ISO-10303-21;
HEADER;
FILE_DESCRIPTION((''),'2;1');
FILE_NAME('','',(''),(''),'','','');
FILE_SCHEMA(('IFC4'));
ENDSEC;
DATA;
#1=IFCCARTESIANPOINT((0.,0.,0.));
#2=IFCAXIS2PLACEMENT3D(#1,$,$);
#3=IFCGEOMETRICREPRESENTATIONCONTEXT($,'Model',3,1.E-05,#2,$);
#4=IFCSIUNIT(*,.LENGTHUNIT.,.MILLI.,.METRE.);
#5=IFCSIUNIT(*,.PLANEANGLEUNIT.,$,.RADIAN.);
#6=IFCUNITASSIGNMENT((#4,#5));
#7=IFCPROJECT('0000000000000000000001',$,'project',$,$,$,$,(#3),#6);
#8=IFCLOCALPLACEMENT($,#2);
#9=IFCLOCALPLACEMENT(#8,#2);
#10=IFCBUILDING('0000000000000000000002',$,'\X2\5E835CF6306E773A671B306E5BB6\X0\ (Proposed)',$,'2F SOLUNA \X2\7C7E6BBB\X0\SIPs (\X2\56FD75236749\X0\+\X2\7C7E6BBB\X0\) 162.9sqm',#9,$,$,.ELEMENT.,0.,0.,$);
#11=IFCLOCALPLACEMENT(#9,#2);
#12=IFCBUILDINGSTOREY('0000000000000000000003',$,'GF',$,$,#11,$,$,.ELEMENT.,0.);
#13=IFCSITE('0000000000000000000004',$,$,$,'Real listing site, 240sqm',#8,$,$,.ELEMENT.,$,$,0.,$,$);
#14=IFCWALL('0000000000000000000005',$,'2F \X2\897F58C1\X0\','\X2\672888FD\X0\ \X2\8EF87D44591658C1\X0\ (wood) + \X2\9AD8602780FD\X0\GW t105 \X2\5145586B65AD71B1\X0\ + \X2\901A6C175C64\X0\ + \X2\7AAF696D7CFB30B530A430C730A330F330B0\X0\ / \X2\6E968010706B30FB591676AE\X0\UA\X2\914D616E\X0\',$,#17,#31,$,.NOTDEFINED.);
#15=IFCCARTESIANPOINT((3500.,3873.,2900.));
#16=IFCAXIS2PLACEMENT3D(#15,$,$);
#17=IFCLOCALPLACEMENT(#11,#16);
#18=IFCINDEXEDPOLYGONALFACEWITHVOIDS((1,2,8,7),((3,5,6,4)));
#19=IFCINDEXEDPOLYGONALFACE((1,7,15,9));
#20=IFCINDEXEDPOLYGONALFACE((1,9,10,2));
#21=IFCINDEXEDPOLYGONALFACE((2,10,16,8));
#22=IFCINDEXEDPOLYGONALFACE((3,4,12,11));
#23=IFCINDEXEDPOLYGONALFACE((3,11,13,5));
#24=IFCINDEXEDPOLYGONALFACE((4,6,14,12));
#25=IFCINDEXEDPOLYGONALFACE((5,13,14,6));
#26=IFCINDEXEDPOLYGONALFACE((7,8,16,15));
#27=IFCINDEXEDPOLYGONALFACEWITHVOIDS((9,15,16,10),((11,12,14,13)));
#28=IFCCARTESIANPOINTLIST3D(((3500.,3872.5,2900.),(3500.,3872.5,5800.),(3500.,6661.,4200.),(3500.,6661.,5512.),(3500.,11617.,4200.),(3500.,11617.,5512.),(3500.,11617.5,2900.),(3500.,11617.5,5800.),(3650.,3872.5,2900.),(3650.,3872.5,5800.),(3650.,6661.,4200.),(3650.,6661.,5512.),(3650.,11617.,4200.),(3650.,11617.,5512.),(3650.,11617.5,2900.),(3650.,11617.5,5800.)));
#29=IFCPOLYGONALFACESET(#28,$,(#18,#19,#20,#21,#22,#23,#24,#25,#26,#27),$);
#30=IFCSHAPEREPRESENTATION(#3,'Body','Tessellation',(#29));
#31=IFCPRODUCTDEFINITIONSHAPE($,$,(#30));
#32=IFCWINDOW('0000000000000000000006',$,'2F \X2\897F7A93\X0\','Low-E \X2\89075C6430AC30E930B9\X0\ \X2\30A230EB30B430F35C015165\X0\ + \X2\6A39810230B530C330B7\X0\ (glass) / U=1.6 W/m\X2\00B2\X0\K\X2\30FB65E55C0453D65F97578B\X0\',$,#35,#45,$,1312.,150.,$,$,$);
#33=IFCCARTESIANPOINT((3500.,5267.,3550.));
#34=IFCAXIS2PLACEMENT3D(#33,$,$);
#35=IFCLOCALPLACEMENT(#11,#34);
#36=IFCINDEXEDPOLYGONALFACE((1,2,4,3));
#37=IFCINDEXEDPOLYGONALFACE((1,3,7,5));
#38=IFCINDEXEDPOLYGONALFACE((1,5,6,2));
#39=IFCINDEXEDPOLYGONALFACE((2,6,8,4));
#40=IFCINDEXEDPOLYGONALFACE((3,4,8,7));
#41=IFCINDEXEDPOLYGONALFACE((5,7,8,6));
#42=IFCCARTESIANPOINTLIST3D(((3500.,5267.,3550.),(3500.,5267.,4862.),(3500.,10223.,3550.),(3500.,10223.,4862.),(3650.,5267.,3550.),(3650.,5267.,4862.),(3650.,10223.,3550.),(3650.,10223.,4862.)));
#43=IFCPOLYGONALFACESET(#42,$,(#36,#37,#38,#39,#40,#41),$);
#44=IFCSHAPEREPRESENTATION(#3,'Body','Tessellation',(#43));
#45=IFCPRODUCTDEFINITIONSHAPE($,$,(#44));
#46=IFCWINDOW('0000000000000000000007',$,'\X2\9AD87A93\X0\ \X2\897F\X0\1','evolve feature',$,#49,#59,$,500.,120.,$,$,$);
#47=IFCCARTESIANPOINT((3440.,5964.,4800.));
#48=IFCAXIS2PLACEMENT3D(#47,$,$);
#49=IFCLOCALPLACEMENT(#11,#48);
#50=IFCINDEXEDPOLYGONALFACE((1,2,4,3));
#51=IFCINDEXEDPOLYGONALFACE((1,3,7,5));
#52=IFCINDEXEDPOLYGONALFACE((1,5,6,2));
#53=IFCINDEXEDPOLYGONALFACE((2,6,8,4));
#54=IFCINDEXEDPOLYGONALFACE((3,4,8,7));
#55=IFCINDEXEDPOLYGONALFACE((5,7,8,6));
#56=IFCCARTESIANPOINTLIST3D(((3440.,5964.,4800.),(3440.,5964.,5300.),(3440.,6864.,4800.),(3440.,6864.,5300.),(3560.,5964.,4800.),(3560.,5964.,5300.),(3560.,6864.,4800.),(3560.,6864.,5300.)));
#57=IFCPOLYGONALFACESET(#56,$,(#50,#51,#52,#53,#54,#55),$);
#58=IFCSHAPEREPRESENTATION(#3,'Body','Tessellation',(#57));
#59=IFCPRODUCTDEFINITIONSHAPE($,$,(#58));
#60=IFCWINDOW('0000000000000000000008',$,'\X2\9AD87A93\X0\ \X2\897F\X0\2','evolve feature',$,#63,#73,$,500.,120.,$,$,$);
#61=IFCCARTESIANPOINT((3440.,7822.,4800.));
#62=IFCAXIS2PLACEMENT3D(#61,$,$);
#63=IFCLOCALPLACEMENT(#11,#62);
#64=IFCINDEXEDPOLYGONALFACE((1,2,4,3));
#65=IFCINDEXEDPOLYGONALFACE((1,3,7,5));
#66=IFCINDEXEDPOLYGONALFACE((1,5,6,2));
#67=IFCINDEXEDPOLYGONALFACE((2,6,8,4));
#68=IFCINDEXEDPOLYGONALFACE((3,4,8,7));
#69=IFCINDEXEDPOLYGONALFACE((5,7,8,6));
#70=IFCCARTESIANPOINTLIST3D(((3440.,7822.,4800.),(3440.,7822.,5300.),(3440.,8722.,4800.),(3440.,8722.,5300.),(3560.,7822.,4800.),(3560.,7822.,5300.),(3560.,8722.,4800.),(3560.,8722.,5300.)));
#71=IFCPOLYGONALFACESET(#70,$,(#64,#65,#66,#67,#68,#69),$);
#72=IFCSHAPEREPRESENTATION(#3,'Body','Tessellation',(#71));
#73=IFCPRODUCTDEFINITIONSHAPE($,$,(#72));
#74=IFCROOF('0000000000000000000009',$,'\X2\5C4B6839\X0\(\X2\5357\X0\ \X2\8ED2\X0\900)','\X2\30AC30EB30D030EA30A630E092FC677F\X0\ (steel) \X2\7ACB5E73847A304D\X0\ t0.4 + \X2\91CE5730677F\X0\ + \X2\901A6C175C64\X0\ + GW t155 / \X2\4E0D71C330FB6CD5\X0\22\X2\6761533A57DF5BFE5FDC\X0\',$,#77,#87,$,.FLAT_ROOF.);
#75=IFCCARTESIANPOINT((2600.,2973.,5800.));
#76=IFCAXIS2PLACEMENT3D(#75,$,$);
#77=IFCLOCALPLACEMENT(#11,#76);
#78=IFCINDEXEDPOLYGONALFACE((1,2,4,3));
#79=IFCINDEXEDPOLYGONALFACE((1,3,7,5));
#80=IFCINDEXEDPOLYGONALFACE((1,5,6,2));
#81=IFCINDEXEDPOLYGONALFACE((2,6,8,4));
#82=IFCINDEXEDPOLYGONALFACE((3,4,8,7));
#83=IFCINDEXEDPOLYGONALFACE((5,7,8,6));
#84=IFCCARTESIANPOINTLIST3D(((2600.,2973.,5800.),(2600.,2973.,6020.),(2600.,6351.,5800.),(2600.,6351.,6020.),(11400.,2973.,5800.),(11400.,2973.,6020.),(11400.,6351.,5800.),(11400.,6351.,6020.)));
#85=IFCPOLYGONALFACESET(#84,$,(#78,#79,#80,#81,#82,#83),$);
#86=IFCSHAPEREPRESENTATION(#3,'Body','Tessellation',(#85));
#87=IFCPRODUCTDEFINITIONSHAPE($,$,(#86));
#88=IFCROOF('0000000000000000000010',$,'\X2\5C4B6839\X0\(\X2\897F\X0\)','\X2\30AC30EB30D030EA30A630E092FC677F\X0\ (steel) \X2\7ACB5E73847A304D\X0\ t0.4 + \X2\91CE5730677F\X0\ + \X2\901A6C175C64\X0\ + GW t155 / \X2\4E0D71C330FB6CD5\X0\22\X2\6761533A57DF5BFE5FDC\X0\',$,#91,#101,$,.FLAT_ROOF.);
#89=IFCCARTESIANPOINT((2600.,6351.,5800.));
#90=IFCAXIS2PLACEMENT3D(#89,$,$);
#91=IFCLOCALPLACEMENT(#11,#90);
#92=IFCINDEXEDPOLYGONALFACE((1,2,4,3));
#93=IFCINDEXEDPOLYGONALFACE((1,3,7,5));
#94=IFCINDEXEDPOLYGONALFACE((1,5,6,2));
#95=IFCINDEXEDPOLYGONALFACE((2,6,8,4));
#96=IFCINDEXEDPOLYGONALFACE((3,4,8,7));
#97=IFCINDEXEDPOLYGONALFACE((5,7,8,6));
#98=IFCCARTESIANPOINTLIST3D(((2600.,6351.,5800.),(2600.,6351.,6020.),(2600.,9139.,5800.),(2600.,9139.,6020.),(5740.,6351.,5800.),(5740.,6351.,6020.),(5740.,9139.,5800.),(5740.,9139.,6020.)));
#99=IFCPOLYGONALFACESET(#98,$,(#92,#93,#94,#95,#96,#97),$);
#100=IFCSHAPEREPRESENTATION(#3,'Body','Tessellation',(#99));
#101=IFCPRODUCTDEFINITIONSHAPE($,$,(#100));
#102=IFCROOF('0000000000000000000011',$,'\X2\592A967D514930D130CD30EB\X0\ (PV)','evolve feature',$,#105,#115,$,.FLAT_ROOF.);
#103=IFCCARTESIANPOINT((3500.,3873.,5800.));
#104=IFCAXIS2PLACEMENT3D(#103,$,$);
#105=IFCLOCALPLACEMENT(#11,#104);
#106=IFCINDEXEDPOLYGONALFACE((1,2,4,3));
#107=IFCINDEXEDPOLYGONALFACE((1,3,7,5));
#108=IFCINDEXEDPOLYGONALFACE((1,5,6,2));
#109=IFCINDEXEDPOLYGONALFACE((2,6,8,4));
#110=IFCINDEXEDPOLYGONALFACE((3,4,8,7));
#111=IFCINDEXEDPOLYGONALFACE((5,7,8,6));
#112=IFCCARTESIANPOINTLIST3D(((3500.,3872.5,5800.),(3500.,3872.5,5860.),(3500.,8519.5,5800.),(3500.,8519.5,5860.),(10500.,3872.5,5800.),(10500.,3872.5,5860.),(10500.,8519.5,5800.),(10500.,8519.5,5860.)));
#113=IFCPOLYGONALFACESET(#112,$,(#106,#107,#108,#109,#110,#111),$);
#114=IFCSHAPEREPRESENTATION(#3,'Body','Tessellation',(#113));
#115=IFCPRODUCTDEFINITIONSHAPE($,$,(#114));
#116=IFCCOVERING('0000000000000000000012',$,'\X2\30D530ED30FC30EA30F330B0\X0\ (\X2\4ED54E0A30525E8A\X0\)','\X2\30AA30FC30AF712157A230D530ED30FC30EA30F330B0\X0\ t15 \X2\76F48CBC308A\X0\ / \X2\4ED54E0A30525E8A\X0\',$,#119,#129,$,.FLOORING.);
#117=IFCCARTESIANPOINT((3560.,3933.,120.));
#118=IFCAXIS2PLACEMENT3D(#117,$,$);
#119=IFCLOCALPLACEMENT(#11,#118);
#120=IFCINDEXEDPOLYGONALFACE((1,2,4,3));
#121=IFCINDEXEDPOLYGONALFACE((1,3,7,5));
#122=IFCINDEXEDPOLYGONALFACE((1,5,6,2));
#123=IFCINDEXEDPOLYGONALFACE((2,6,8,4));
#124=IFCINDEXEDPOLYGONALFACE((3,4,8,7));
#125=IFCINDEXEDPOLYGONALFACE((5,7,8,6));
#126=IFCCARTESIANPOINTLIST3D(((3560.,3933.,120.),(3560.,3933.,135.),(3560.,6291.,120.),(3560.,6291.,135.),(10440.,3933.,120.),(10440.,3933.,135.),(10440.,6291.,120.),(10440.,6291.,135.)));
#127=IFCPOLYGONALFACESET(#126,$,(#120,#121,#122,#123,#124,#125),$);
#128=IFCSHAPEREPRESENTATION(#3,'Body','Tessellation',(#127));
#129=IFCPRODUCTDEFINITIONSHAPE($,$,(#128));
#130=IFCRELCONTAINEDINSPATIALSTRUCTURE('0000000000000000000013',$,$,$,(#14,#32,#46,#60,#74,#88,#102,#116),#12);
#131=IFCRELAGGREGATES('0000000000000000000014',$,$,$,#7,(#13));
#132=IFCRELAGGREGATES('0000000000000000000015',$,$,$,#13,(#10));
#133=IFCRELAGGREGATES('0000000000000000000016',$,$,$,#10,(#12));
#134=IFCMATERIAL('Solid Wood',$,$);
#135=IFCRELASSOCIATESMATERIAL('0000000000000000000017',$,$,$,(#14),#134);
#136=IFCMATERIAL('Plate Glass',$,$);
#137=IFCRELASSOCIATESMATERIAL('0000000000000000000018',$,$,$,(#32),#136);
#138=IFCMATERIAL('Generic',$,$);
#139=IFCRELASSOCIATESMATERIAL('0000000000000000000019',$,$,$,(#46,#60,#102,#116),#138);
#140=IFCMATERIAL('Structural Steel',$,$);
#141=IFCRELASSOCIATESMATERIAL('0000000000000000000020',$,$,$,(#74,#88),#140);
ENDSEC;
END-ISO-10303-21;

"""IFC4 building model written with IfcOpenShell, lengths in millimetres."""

from ifc_helpers import new_model, si_unit, frame, frame_2d, origin, place, context, project, spatial, rectangle, extrude, material, element, fill, save


model = new_model("IFC4")

# Units and contexts
model_context = context("Model", 3, precision=1e-05, world=origin())
ifc_project = project(units=[si_unit("LENGTHUNIT", "METRE", prefix="MILLI"), si_unit("PLANEANGLEUNIT", "RADIAN")], contexts=[model_context])

# Site, building, storey
site_placement = place(None, origin())
site = spatial("IfcSite", under=ifc_project, at=site_placement, ObjectType="Real listing site, 240sqm", CompositionType="ELEMENT", RefElevation=0.0)
building_placement = place(site_placement, origin())
building = spatial("IfcBuilding", under=site, at=building_placement, Name="広島の眺望の家 (Proposed)", ObjectType="2F SOLUNA 籾殻SIPs (国産杉+籾殻) 162.9sqm", CompositionType="ELEMENT", ElevationOfRefHeight=0.0, ElevationOfTerrain=0.0)
storey_placement = place(building_placement, origin())
storey = spatial("IfcBuildingStorey", under=building, at=storey_placement, Name="GF", CompositionType="ELEMENT", Elevation=0.0)

# Shared definitions
ifc_material_1 = material(Name="Solid Wood")
ifc_material_2 = material(Name="Generic")

# Shared definitions
ifc_material_3 = material(Name="Plate Glass")

# Wall, openings, windows
wall_1_placement = place(storey_placement, frame((3500.0, 3873.0, 2900.0)))
wall_1 = element("IfcWall", 1, at=wall_1_placement, inside=storey, material=ifc_material_1, Name="2F 西壁", Description="木製 軸組外壁 (wood) + 高性能GW t105 充填断熱 + 通気層 + 窯業系サイディング / 準耐火・外皮UA配慮", PredefinedType="NOTDEFINED", context=model_context, shape_type="SweptSolid", body=[
    extrude(rectangle(XDim=150.0, YDim=7745.0, at=frame_2d((75.0, 3872.0))), frame((3500.0, 3873.0, 2900.0)), (0.0, 0.0, 1.0), 2900.0),
])
opening_1_placement = place(storey_placement, frame((3500.0, 5267.0, 3550.0)))
opening_1 = element("IfcOpeningElement", 2, at=opening_1_placement, cuts=wall_1, PredefinedType="NOTDEFINED", context=model_context, shape_type="SweptSolid", body=[
    extrude(rectangle(XDim=150.0, YDim=4956.0, at=frame_2d((75.0, 2478.0))), frame((3500.0, 5267.0, 3550.0)), (0.0, 0.0, 1.0), 1312.0),
])
opening_2_placement = place(storey_placement, frame((3440.0, 5964.0, 4800.0)))
opening_2 = element("IfcOpeningElement", 3, at=opening_2_placement, cuts=wall_1, PredefinedType="NOTDEFINED", context=model_context, shape_type="SweptSolid", body=[
    extrude(rectangle(XDim=120.0, YDim=900.0, at=frame_2d((60.0, 450.0))), frame((3440.0, 5964.0, 4800.0)), (0.0, 0.0, 1.0), 500.0),
])
opening_3_placement = place(storey_placement, frame((3440.0, 7822.0, 4800.0)))
opening_3 = element("IfcOpeningElement", 4, at=opening_3_placement, cuts=wall_1, PredefinedType="NOTDEFINED", context=model_context, shape_type="SweptSolid", body=[
    extrude(rectangle(XDim=120.0, YDim=900.0, at=frame_2d((60.0, 450.0))), frame((3440.0, 7822.0, 4800.0)), (0.0, 0.0, 1.0), 500.0),
])
window_1_placement = place(storey_placement, frame((3500.0, 5267.0, 3550.0)))
window_1 = element("IfcWindow", 5, at=window_1_placement, inside=storey, material=ifc_material_3, Name="2F 西窓", Description="Low-E 複層ガラス アルゴン封入 + 樹脂サッシ (glass) / U=1.6 W/m²K・日射取得型", OverallHeight=1312.0, OverallWidth=150.0, context=model_context, shape_type="SweptSolid", body=[
    extrude(rectangle(XDim=150.0, YDim=4956.0, at=frame_2d((75.0, 2478.0))), frame((3500.0, 5267.0, 3550.0)), (0.0, 0.0, 1.0), 1312.0),
])
fill(opening_1, window_1)
window_2_placement = place(storey_placement, frame((3440.0, 5964.0, 4800.0)))
window_2 = element("IfcWindow", 6, at=window_2_placement, inside=storey, material=ifc_material_2, Name="高窓 西1", Description="evolve feature", OverallHeight=500.0, OverallWidth=120.0, context=model_context, shape_type="SweptSolid", body=[
    extrude(rectangle(XDim=120.0, YDim=900.0, at=frame_2d((60.0, 450.0))), frame((3440.0, 5964.0, 4800.0)), (0.0, 0.0, 1.0), 500.0),
])
fill(opening_2, window_2)
window_3_placement = place(storey_placement, frame((3440.0, 7822.0, 4800.0)))
window_3 = element("IfcWindow", 7, at=window_3_placement, inside=storey, material=ifc_material_2, Name="高窓 西2", Description="evolve feature", OverallHeight=500.0, OverallWidth=120.0, context=model_context, shape_type="SweptSolid", body=[
    extrude(rectangle(XDim=120.0, YDim=900.0, at=frame_2d((60.0, 450.0))), frame((3440.0, 7822.0, 4800.0)), (0.0, 0.0, 1.0), 500.0),
])
fill(opening_3, window_3)

# Roofs
ifc_material_4 = material(Name="Structural Steel")
roof_1_placement = place(storey_placement, frame((2600.0, 2973.0, 5800.0)))
element("IfcRoof", 8, at=roof_1_placement, inside=storey, material=ifc_material_4, Name="屋根(南 軒900)", Description="ガルバリウム鋼板 (steel) 立平葺き t0.4 + 野地板 + 通気層 + GW t155 / 不燃・法22条区域対応", PredefinedType="FLAT_ROOF", context=model_context, shape_type="SweptSolid", body=[
    extrude(rectangle(XDim=8800.0, YDim=3378.0, at=frame_2d((4400.0, 1689.0))), frame((2600.0, 2973.0, 5800.0)), (0.0, 0.0, 1.0), 220.0),
])
roof_2_placement = place(storey_placement, frame((2600.0, 6351.0, 5800.0)))
element("IfcRoof", 9, at=roof_2_placement, inside=storey, material=ifc_material_4, Name="屋根(西)", Description="ガルバリウム鋼板 (steel) 立平葺き t0.4 + 野地板 + 通気層 + GW t155 / 不燃・法22条区域対応", PredefinedType="FLAT_ROOF", context=model_context, shape_type="SweptSolid", body=[
    extrude(rectangle(XDim=3140.0, YDim=2788.0, at=frame_2d((1570.0, 1394.0))), frame((2600.0, 6351.0, 5800.0)), (0.0, 0.0, 1.0), 220.0),
])
roof_3_placement = place(storey_placement, frame((3500.0, 3873.0, 5800.0)))
element("IfcRoof", 10, at=roof_3_placement, inside=storey, material=ifc_material_2, Name="太陽光パネル (PV)", Description="evolve feature", PredefinedType="FLAT_ROOF", context=model_context, shape_type="SweptSolid", body=[
    extrude(rectangle(XDim=7000.0, YDim=4647.0, at=frame_2d((3500.0, 2323.0))), frame((3500.0, 3873.0, 5800.0)), (0.0, 0.0, 1.0), 60.0),
])

# Covering
covering_placement = place(storey_placement, frame((3560.0, 3933.0, 120.0)))
element("IfcCovering", 11, at=covering_placement, inside=storey, material=ifc_material_2, Name="フローリング (仕上げ床)", Description="オーク無垢フローリング t15 直貼り / 仕上げ床", PredefinedType="FLOORING", context=model_context, shape_type="SweptSolid", body=[
    extrude(rectangle(XDim=6880.0, YDim=2358.0, at=frame_2d((3440.0, 1179.0))), frame((3560.0, 3933.0, 120.0)), (0.0, 0.0, 1.0), 15.0),
])

save(model, "model.ifc")
